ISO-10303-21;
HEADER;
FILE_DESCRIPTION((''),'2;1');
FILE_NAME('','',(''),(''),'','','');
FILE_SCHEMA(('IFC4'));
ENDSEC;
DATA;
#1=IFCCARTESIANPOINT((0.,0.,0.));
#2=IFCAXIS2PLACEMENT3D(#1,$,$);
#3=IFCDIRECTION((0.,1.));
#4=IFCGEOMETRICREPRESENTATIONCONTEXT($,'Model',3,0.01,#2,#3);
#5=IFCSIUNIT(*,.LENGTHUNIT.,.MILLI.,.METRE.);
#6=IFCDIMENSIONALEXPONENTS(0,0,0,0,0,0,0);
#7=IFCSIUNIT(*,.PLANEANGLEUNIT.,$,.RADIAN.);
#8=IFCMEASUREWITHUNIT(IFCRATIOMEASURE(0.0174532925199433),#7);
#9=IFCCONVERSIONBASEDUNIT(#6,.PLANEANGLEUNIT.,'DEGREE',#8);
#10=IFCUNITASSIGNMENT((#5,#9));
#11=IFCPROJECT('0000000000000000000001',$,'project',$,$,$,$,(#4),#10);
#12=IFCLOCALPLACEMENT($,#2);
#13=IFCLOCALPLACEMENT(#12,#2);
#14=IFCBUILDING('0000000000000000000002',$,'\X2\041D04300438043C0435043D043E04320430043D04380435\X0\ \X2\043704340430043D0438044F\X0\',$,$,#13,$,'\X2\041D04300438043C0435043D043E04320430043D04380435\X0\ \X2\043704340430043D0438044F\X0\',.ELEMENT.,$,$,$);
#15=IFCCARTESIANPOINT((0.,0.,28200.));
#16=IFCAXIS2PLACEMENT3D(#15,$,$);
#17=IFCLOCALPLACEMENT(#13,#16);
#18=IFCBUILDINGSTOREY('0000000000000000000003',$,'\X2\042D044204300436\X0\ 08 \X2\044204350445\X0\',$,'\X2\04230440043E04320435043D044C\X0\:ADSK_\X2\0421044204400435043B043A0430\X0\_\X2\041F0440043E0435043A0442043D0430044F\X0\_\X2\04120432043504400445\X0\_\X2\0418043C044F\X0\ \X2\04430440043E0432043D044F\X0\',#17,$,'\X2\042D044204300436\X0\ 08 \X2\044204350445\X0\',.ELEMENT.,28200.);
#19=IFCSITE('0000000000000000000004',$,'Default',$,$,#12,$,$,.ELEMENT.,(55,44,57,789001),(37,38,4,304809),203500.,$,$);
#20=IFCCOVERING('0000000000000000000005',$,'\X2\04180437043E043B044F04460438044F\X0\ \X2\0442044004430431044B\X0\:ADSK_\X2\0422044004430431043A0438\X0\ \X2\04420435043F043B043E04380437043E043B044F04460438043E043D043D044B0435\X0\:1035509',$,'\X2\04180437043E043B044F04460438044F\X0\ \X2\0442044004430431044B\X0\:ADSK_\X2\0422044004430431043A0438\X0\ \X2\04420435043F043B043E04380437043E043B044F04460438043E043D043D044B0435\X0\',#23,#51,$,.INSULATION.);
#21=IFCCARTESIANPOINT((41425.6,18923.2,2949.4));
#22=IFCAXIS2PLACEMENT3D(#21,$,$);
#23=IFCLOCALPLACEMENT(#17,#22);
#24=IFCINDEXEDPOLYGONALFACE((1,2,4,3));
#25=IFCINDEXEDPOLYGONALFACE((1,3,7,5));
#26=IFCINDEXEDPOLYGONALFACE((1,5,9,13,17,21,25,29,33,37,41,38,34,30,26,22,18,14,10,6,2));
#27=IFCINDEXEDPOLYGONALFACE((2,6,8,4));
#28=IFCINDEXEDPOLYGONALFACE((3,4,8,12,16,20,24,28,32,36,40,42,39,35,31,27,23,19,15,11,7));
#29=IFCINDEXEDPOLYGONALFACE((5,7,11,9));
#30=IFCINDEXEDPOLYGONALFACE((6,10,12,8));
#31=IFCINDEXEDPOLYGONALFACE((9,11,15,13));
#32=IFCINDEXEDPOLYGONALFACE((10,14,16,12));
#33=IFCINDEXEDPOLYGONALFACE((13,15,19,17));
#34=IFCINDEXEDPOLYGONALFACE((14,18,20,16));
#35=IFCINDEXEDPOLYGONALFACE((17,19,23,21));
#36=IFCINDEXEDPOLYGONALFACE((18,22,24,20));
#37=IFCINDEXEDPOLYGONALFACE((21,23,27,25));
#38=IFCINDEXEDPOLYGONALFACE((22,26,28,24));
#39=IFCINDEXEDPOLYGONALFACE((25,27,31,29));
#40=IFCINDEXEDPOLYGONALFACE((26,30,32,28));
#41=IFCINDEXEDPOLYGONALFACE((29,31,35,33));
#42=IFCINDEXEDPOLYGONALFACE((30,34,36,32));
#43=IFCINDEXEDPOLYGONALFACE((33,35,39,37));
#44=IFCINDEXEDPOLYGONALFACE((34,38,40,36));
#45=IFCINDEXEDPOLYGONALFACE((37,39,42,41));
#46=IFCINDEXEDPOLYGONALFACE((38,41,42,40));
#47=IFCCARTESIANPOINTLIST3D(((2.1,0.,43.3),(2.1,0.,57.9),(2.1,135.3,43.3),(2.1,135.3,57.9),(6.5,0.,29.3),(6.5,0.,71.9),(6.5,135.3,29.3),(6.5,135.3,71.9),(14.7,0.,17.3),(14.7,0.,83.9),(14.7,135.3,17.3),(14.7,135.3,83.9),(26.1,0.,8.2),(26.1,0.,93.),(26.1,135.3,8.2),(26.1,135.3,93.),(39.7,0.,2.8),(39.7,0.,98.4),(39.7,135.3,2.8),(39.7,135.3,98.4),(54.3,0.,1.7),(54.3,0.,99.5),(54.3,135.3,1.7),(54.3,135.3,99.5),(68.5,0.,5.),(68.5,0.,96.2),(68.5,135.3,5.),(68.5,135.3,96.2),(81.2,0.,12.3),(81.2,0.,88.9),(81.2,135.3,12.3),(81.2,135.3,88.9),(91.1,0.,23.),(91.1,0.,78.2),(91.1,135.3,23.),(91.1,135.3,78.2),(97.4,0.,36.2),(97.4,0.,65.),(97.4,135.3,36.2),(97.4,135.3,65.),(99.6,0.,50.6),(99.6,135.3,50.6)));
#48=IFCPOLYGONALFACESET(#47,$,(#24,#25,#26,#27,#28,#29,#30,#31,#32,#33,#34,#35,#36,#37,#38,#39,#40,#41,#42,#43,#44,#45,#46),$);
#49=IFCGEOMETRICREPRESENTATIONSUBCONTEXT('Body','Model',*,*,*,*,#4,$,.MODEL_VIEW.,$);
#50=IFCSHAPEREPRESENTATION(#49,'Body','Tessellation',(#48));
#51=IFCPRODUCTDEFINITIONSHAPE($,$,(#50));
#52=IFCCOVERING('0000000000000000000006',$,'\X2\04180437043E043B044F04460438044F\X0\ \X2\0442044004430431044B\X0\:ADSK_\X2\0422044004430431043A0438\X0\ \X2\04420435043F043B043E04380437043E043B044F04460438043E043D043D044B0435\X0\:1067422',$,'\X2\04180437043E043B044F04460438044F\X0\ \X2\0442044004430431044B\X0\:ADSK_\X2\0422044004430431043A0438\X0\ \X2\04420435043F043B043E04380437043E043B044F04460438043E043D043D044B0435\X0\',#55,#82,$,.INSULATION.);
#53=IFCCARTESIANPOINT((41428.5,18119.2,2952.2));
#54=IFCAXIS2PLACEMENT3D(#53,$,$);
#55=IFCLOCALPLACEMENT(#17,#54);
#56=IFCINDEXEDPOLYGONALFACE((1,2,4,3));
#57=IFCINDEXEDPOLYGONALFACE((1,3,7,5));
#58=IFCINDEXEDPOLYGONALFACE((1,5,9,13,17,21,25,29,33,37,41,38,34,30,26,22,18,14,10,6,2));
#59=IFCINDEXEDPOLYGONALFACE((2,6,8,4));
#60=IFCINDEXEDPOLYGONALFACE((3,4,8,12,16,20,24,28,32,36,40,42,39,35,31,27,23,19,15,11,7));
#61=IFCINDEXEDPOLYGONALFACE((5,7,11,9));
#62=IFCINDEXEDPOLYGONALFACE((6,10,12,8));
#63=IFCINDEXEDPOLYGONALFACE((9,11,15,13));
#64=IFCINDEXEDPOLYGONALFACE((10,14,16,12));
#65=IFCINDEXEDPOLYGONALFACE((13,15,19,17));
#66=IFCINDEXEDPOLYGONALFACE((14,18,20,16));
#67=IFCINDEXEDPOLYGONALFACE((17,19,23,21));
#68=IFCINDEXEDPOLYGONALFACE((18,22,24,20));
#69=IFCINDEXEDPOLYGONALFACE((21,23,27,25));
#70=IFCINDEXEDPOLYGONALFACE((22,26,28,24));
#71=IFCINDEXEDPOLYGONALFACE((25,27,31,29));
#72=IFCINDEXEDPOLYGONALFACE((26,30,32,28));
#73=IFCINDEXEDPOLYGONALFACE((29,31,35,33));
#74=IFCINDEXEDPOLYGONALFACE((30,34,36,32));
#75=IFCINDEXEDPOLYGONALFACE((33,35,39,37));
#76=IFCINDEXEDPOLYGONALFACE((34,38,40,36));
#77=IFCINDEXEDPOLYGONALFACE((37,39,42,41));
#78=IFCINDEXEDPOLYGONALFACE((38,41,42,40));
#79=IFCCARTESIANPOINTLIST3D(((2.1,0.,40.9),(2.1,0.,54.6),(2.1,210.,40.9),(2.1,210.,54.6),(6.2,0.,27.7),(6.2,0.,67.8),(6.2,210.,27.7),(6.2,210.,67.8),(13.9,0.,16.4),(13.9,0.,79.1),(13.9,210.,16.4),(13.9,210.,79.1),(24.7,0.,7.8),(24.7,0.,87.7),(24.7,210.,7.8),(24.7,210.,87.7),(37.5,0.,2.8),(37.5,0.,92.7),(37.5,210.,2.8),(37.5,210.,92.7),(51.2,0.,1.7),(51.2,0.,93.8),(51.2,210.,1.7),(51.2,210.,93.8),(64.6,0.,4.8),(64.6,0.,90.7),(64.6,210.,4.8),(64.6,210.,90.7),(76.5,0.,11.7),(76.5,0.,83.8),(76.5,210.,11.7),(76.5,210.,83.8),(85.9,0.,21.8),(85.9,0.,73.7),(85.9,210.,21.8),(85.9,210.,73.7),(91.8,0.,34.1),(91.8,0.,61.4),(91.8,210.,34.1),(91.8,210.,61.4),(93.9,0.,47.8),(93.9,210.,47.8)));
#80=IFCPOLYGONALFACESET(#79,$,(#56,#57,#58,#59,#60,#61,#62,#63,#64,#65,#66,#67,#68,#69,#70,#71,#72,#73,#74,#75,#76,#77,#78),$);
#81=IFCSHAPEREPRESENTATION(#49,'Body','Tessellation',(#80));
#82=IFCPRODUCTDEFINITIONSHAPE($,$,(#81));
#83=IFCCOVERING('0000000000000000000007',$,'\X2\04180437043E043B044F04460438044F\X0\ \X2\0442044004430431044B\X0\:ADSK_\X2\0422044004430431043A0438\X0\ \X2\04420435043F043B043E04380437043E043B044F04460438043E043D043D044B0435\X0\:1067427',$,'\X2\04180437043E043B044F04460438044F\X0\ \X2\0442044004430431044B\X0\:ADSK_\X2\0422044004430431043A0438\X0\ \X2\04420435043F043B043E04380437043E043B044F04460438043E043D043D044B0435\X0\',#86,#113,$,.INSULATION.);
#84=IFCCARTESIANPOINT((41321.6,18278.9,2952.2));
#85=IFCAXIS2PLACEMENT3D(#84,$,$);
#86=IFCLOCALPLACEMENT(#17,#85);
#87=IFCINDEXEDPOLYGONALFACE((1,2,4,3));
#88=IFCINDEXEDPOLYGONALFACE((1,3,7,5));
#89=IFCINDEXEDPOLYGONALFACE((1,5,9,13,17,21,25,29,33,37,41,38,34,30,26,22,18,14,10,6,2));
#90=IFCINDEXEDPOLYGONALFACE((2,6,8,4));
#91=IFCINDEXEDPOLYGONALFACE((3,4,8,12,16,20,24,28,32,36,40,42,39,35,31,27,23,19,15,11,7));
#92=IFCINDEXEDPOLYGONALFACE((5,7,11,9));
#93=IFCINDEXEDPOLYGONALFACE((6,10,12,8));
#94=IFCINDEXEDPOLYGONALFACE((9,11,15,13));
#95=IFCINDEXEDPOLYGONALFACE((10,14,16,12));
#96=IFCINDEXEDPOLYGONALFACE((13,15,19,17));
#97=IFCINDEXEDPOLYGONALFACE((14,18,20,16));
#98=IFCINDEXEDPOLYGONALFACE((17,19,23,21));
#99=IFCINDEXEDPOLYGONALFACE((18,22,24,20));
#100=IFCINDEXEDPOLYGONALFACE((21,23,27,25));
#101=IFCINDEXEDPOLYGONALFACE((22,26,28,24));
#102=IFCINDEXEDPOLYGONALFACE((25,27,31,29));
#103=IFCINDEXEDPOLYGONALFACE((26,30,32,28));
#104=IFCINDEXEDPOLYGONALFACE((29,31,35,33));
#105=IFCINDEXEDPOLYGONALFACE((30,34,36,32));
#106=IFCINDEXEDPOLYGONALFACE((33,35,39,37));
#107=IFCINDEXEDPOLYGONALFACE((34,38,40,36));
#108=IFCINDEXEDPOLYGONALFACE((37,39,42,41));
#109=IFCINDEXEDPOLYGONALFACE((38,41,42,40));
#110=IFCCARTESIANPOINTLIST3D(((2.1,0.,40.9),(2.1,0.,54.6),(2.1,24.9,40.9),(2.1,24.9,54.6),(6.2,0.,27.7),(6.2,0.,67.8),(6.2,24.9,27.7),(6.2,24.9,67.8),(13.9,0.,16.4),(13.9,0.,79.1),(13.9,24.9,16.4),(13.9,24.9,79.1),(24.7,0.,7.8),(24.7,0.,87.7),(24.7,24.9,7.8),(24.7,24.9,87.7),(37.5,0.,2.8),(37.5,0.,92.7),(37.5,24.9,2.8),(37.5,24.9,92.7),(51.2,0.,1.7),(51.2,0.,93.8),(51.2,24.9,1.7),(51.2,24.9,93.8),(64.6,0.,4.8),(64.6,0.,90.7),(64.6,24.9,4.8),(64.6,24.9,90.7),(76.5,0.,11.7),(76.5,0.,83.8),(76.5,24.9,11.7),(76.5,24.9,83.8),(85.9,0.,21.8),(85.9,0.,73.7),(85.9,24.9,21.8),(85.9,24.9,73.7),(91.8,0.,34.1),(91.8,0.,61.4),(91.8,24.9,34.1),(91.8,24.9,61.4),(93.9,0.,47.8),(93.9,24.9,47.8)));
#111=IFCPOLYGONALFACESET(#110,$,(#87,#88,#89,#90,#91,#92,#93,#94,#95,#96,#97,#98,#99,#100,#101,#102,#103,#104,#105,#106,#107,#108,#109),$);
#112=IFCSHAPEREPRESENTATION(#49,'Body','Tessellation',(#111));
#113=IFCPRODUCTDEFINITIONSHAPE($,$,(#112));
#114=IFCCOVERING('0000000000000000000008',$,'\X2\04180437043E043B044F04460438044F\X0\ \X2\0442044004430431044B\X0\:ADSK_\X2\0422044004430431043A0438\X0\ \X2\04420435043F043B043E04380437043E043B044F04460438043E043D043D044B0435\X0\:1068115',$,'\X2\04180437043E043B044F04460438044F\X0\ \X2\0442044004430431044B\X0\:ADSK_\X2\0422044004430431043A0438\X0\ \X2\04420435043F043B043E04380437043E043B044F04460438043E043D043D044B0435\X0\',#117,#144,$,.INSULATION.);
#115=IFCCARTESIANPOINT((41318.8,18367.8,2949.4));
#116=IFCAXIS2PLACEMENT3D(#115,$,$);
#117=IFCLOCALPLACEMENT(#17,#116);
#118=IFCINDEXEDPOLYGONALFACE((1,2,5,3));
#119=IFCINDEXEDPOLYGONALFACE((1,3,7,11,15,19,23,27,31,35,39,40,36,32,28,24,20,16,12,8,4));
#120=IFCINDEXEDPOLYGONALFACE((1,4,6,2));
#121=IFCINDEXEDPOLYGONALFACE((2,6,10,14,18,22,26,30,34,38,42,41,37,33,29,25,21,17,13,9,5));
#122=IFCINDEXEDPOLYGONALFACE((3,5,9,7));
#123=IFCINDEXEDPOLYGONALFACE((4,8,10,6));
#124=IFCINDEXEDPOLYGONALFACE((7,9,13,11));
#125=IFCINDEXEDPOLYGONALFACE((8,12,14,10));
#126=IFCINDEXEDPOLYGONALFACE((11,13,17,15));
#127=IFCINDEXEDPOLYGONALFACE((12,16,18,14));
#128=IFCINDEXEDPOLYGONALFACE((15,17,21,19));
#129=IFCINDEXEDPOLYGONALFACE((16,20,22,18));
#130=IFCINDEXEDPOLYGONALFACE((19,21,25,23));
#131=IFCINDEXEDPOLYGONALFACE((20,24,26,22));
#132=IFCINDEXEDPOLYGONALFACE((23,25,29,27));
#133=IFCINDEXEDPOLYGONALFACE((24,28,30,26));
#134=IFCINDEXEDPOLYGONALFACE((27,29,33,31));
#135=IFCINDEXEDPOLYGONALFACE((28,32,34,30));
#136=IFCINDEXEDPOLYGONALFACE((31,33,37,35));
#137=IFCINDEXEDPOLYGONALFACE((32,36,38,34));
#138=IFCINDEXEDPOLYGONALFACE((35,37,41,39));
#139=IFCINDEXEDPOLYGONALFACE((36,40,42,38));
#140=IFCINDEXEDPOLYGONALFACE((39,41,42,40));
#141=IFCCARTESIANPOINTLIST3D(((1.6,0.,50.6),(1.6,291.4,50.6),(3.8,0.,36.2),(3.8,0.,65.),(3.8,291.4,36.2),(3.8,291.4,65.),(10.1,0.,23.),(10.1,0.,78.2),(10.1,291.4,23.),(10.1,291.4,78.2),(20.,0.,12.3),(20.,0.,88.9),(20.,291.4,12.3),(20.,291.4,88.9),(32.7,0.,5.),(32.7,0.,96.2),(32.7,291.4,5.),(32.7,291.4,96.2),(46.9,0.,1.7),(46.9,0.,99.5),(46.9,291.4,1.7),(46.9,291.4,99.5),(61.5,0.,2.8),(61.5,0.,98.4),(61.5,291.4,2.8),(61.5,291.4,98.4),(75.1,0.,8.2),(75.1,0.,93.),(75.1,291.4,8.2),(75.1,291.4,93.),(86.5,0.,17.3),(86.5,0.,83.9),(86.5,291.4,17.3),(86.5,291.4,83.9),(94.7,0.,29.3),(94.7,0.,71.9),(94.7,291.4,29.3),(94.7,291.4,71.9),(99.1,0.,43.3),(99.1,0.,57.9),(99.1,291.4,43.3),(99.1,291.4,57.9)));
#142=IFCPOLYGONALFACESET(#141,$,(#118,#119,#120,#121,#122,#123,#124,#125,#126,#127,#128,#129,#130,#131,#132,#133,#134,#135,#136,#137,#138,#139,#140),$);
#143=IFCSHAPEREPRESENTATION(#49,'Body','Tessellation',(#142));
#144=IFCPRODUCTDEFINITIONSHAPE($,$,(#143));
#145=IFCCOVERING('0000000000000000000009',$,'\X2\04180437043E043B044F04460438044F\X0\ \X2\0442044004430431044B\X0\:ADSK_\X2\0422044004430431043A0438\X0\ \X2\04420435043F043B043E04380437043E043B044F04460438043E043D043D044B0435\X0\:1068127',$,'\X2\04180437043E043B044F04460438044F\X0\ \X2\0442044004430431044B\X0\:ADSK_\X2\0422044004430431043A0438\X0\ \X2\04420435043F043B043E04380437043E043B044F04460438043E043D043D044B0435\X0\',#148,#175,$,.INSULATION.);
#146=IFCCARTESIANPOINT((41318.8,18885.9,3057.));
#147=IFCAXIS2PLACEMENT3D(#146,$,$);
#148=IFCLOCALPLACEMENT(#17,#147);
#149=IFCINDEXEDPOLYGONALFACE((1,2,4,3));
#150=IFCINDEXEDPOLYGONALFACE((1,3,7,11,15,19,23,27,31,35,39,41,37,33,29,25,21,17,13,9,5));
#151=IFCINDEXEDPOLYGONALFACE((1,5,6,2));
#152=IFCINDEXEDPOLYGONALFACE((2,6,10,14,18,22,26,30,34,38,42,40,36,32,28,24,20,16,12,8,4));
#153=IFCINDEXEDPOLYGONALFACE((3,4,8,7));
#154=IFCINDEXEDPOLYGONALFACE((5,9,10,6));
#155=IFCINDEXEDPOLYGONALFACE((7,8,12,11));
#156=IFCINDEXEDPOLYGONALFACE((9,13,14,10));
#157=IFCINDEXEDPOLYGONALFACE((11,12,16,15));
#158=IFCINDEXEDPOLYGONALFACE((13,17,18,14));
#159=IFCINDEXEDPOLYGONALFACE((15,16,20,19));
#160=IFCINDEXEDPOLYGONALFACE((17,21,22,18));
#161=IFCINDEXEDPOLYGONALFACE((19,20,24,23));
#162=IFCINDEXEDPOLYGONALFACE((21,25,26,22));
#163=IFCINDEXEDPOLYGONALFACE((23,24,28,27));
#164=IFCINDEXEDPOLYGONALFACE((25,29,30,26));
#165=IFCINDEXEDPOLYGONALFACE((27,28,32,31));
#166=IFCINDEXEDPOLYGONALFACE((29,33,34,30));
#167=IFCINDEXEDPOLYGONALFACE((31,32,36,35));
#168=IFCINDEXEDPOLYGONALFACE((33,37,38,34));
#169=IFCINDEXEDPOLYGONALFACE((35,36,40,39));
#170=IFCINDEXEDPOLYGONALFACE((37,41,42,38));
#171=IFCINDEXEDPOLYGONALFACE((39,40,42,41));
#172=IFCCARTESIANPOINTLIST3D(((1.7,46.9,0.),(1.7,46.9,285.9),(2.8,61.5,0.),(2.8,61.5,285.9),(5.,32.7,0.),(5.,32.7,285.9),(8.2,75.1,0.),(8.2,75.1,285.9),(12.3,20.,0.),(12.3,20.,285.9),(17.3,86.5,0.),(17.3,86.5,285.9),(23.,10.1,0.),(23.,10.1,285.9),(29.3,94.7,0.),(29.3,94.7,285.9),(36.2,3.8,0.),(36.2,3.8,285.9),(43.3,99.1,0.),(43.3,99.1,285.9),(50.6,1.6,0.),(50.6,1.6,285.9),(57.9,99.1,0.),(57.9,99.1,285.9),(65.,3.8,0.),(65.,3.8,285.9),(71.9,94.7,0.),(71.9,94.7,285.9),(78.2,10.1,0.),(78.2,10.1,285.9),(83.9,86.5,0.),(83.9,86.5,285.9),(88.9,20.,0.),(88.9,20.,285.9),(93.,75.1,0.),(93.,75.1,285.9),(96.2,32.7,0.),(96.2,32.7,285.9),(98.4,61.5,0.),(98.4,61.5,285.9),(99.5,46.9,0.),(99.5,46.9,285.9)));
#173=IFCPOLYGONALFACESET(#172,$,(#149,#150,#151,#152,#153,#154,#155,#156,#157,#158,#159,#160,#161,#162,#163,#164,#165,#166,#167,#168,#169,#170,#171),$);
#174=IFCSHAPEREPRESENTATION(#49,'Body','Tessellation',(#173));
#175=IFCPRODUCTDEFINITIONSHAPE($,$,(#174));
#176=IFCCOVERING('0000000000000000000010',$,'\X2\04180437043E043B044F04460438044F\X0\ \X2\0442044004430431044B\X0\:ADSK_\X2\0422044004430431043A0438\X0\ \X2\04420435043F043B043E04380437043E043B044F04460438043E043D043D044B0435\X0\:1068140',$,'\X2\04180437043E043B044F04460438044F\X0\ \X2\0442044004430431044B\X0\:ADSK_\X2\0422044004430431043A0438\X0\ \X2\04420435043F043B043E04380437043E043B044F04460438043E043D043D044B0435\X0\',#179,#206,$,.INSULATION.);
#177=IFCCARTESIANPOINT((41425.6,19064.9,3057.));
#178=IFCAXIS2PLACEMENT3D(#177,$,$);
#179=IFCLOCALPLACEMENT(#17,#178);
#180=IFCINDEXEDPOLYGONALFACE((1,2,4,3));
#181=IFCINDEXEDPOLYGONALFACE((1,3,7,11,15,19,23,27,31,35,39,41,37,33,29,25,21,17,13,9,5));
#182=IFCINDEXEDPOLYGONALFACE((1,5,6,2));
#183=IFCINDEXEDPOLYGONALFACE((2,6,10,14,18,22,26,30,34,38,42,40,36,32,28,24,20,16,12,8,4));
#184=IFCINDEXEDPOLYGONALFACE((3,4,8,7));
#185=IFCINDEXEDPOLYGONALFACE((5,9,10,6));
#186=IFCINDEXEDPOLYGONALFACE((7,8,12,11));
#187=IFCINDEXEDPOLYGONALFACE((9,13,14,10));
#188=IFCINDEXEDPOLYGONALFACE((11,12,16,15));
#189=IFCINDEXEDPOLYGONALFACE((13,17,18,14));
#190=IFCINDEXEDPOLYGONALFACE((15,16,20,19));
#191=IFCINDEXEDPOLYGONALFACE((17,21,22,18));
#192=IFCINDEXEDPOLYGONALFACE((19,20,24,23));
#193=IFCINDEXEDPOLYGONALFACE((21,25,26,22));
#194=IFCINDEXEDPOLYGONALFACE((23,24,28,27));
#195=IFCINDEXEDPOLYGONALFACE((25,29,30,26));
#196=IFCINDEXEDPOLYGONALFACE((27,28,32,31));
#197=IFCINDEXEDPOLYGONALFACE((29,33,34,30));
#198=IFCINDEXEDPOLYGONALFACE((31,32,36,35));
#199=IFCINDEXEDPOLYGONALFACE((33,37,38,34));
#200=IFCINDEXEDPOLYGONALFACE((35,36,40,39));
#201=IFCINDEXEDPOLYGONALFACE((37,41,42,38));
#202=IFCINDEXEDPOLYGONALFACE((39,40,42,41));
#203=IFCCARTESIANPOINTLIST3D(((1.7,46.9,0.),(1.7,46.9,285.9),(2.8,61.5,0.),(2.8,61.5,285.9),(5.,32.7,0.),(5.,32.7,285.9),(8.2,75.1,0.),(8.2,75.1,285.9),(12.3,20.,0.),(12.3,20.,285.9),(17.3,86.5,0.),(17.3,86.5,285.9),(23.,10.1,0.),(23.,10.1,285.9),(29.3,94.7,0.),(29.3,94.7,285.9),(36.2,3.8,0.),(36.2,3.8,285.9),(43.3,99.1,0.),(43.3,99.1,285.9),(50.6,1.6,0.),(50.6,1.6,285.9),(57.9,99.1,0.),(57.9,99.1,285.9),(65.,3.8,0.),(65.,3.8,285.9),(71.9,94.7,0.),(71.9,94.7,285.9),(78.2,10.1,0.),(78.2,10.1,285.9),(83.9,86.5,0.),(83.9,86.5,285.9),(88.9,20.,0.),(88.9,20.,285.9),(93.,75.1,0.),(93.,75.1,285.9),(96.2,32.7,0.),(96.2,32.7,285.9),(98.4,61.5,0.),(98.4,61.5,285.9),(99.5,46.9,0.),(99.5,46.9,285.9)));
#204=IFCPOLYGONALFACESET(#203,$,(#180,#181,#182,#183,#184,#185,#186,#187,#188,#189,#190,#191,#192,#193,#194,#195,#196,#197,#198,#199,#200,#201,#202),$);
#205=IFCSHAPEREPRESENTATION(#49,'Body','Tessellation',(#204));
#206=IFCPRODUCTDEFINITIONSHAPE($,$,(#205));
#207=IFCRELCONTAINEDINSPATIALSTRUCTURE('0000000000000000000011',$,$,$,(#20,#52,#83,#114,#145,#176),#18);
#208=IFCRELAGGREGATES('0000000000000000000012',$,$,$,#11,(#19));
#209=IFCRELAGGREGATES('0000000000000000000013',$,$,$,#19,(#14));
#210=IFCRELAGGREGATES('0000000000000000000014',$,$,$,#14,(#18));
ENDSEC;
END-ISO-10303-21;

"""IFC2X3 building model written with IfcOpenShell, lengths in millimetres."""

from ifc_helpers import new_model, entity, si_unit, converted_unit, direction, frame, origin, origin_2d_with_axis, place, context, subcontext, project, spatial, circle, extrude, element, save


model = new_model("IFC2X3")

# Units and contexts
model_context = context("Model", 3, precision=0.01, world=origin(), true_north=direction((0.0, 1.0)))
body_context = subcontext(model_context, "Body", "Model", "MODEL_VIEW")
ifc_project = project(units=[si_unit("LENGTHUNIT", "METRE", prefix="MILLI"), converted_unit("PLANEANGLEUNIT", "DEGREE", entity("IfcRatioMeasure", 0.0174532925199433), si_unit("PLANEANGLEUNIT", "RADIAN"), dimensions=[0, 0, 0, 0, 0, 0, 0])], contexts=[model_context])

# Site, building, storey
site_placement = place(None, origin())
site = spatial("IfcSite", under=ifc_project, at=site_placement, Name="Default", CompositionType="ELEMENT", RefLatitude=(55, 44, 57, 789001), RefLongitude=(37, 38, 4, 304809), RefElevation=203500.0)
building_placement = place(site_placement, origin())
building = spatial("IfcBuilding", under=site, at=building_placement, Name="Наименование здания", LongName="Наименование здания", CompositionType="ELEMENT")
storey_placement = place(building_placement, frame((0.0, 0.0, 28200.0)))
storey = spatial("IfcBuildingStorey", under=building, at=storey_placement, Name="Этаж 08 тех", ObjectType="Уровень:ADSK_Стрелка_Проектная_Вверх_Имя уровня", LongName="Этаж 08 тех", CompositionType="ELEMENT", Elevation=28200.0)

# Coverings
covering_1_placement = place(storey_placement, frame((41425.6, 18923.2, 2949.4)))
element("IfcCovering", 1, at=covering_1_placement, inside=storey, Name="Изоляция трубы:ADSK_Трубки теплоизоляционные:1035509", ObjectType="Изоляция трубы:ADSK_Трубки теплоизоляционные", PredefinedType="INSULATION", context=body_context, shape_type="SweptSolid", body=[
    extrude(circle(Radius=49.0, at=origin_2d_with_axis()), frame((50.6, 0.0, 50.6), z_axis=(0.0, 1.0, 0.0), x_axis=(1.0, 0.0, 0.0)), (0.0, 0.0, 1.0), 135.3),
])
covering_2_placement = place(storey_placement, frame((41428.5, 18119.2, 2952.2)))
element("IfcCovering", 2, at=covering_2_placement, inside=storey, Name="Изоляция трубы:ADSK_Трубки теплоизоляционные:1067422", ObjectType="Изоляция трубы:ADSK_Трубки теплоизоляционные", PredefinedType="INSULATION", context=body_context, shape_type="SweptSolid", body=[
    extrude(circle(Radius=46.1, at=origin_2d_with_axis()), frame((47.8, 0.0, 47.8), z_axis=(0.0, 1.0, 0.0), x_axis=(1.0, 0.0, 0.0)), (0.0, 0.0, 1.0), 210.0),
])
covering_3_placement = place(storey_placement, frame((41321.6, 18278.9, 2952.2)))
element("IfcCovering", 3, at=covering_3_placement, inside=storey, Name="Изоляция трубы:ADSK_Трубки теплоизоляционные:1067427", ObjectType="Изоляция трубы:ADSK_Трубки теплоизоляционные", PredefinedType="INSULATION", context=body_context, shape_type="SweptSolid", body=[
    extrude(circle(Radius=46.1, at=origin_2d_with_axis()), frame((47.8, 0.0, 47.8), z_axis=(0.0, 1.0, 0.0), x_axis=(1.0, 0.0, 0.0)), (0.0, 0.0, 1.0), 24.9),
])
covering_4_placement = place(storey_placement, frame((41318.8, 18367.8, 2949.4)))
element("IfcCovering", 4, at=covering_4_placement, inside=storey, Name="Изоляция трубы:ADSK_Трубки теплоизоляционные:1068115", ObjectType="Изоляция трубы:ADSK_Трубки теплоизоляционные", PredefinedType="INSULATION", context=body_context, shape_type="SweptSolid", body=[
    extrude(circle(Radius=49.0, at=origin_2d_with_axis()), frame((50.6, 0.0, 50.6), z_axis=(0.0, 1.0, 0.0), x_axis=(-1.0, 0.0, 0.0)), (0.0, 0.0, 1.0), 291.4),
])
for number, where, name in (
    (5, (41318.8, 18885.9, 3057.0), "Изоляция трубы:ADSK_Трубки теплоизоляционные:1068127"),
    (6, (41425.6, 19064.9, 3057.0), "Изоляция трубы:ADSK_Трубки теплоизоляционные:1068140"),
):
    element("IfcCovering", number, at=place(storey_placement, frame(where)), inside=storey, Name=name, ObjectType="Изоляция трубы:ADSK_Трубки теплоизоляционные", PredefinedType="INSULATION", context=body_context, shape_type="SweptSolid", body=[
        extrude(circle(Radius=49.0, at=origin_2d_with_axis()), frame((50.6, 50.6, 0.0), z_axis=(0.0, 0.0, 1.0), x_axis=(0.0, -1.0, 0.0)), (0.0, 0.0, 1.0), 285.9),
    ])

save(model, "model.ifc")
